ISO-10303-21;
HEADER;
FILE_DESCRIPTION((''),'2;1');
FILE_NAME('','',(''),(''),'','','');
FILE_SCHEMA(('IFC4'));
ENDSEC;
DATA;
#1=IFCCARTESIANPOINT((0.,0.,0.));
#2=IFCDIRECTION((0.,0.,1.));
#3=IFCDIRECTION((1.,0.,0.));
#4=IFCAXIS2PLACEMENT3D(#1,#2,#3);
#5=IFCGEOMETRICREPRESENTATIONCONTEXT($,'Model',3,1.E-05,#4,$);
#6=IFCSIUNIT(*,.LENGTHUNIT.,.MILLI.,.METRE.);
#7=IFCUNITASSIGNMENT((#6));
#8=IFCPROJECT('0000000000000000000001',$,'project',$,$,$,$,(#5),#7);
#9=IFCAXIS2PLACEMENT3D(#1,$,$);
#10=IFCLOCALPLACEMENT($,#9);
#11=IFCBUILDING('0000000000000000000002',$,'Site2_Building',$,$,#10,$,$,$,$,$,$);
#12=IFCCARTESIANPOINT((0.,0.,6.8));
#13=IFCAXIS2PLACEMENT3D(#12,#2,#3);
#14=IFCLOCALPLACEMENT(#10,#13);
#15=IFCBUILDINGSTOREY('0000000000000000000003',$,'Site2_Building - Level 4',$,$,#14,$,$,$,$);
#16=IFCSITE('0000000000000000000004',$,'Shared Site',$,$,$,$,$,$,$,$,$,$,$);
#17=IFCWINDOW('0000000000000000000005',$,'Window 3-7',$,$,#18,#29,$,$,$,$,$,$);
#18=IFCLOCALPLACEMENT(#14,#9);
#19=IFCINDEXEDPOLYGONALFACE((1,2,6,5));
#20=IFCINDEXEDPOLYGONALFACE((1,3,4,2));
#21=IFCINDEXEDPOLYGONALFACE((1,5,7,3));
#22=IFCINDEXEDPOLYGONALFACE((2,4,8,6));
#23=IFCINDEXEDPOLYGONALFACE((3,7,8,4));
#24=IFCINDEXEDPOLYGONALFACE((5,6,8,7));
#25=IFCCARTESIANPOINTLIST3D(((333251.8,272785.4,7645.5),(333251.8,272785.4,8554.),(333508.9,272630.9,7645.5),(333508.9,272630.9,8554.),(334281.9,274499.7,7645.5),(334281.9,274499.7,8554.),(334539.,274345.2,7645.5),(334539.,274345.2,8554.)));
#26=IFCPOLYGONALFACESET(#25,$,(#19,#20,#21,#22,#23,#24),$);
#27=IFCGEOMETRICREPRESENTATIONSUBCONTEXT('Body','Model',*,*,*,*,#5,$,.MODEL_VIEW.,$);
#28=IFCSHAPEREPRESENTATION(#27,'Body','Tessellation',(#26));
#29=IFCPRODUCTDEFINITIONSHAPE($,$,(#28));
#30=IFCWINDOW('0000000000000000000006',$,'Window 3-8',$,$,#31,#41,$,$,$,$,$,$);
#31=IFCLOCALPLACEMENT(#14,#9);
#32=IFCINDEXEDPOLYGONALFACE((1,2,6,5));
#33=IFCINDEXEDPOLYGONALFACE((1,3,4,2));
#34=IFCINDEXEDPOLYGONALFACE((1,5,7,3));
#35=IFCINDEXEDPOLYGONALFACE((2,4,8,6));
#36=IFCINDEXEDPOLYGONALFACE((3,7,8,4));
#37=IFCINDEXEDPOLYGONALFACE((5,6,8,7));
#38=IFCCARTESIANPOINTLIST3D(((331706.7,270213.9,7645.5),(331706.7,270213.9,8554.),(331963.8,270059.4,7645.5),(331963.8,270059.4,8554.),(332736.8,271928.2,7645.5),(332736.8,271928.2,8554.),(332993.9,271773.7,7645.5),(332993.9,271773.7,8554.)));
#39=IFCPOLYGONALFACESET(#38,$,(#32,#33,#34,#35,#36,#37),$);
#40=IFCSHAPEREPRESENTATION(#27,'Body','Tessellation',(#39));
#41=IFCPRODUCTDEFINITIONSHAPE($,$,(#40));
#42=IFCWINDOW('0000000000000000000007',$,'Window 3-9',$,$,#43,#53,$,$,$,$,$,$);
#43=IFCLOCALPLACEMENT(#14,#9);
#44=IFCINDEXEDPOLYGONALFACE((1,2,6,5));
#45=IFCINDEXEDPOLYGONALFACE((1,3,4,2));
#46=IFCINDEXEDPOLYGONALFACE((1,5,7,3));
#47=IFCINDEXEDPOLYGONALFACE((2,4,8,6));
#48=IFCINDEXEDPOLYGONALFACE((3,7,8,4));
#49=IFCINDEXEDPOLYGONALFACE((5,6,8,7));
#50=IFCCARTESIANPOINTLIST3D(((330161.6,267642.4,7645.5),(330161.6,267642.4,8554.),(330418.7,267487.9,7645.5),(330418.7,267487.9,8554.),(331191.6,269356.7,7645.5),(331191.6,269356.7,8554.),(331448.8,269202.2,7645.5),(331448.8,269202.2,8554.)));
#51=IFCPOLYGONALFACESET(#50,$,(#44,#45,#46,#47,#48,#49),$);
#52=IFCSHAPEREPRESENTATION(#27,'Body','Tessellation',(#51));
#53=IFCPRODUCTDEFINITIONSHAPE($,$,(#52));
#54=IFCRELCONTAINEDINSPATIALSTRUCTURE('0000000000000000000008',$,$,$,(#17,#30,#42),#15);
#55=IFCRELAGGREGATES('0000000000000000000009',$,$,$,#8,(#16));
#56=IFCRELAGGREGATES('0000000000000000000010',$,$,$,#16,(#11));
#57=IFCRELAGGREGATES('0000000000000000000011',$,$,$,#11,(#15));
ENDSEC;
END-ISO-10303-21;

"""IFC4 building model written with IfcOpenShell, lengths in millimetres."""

from ifc_helpers import new_model, si_unit, frame, origin, origin_with_axes, place, context, subcontext, project, spatial, indexed_curve, outline, extrude, element, save


model = new_model("IFC4")

# Units and contexts
model_context = context("Model", 3, precision=1e-05, world=origin_with_axes())
body_context = subcontext(model_context, "Body", "Model", "MODEL_VIEW")
ifc_project = project(units=[si_unit("LENGTHUNIT", "METRE", prefix="MILLI")], contexts=[model_context])

# Site, building, storey
site = spatial("IfcSite", under=ifc_project, Name="Shared Site")
building_placement = place(None, origin())
building = spatial("IfcBuilding", under=site, at=building_placement, Name="Site2_Building")
storey_placement = place(building_placement, frame((0.0, 0.0, 6.8), z_axis=(0.0, 0.0, 1.0), x_axis=(1.0, 0.0, 0.0)))
storey = spatial("IfcBuildingStorey", under=building, at=storey_placement, Name="Site2_Building - Level 4")

# Windows
for number, where, z_axis, x_axis, name in (
    (1, (334281.9, 274499.7, 7645.5), (0.0, 0.0, 1.0), (-0.515038, -0.857167, 0.0), "Window 3-7"),
    (2, (332736.8, 271928.2, 7645.5), (0.0, 0.0, 1.0), (-0.515038, -0.857167, 0.0), "Window 3-8"),
    (3, (331191.6, 269356.7, 7645.5), (0.0, 0.0, 1.0), (-0.515038, -0.857167, 0.0), "Window 3-9"),
):
    element("IfcWindow", number, at=place(storey_placement, frame(where, z_axis=z_axis, x_axis=x_axis)), inside=storey, Name=name, context=body_context, shape_type="SweptSolid", body=[
        extrude(outline(indexed_curve([(0.0, 0.0), (0.0, 300.0), (2000.0, 300.0), (2000.0, 0.0), (0.0, 0.0)], self_intersect=False)), origin_with_axes(), (0.0, 0.0, 1.0), 908.6),
    ])

save(model, "model.ifc")
